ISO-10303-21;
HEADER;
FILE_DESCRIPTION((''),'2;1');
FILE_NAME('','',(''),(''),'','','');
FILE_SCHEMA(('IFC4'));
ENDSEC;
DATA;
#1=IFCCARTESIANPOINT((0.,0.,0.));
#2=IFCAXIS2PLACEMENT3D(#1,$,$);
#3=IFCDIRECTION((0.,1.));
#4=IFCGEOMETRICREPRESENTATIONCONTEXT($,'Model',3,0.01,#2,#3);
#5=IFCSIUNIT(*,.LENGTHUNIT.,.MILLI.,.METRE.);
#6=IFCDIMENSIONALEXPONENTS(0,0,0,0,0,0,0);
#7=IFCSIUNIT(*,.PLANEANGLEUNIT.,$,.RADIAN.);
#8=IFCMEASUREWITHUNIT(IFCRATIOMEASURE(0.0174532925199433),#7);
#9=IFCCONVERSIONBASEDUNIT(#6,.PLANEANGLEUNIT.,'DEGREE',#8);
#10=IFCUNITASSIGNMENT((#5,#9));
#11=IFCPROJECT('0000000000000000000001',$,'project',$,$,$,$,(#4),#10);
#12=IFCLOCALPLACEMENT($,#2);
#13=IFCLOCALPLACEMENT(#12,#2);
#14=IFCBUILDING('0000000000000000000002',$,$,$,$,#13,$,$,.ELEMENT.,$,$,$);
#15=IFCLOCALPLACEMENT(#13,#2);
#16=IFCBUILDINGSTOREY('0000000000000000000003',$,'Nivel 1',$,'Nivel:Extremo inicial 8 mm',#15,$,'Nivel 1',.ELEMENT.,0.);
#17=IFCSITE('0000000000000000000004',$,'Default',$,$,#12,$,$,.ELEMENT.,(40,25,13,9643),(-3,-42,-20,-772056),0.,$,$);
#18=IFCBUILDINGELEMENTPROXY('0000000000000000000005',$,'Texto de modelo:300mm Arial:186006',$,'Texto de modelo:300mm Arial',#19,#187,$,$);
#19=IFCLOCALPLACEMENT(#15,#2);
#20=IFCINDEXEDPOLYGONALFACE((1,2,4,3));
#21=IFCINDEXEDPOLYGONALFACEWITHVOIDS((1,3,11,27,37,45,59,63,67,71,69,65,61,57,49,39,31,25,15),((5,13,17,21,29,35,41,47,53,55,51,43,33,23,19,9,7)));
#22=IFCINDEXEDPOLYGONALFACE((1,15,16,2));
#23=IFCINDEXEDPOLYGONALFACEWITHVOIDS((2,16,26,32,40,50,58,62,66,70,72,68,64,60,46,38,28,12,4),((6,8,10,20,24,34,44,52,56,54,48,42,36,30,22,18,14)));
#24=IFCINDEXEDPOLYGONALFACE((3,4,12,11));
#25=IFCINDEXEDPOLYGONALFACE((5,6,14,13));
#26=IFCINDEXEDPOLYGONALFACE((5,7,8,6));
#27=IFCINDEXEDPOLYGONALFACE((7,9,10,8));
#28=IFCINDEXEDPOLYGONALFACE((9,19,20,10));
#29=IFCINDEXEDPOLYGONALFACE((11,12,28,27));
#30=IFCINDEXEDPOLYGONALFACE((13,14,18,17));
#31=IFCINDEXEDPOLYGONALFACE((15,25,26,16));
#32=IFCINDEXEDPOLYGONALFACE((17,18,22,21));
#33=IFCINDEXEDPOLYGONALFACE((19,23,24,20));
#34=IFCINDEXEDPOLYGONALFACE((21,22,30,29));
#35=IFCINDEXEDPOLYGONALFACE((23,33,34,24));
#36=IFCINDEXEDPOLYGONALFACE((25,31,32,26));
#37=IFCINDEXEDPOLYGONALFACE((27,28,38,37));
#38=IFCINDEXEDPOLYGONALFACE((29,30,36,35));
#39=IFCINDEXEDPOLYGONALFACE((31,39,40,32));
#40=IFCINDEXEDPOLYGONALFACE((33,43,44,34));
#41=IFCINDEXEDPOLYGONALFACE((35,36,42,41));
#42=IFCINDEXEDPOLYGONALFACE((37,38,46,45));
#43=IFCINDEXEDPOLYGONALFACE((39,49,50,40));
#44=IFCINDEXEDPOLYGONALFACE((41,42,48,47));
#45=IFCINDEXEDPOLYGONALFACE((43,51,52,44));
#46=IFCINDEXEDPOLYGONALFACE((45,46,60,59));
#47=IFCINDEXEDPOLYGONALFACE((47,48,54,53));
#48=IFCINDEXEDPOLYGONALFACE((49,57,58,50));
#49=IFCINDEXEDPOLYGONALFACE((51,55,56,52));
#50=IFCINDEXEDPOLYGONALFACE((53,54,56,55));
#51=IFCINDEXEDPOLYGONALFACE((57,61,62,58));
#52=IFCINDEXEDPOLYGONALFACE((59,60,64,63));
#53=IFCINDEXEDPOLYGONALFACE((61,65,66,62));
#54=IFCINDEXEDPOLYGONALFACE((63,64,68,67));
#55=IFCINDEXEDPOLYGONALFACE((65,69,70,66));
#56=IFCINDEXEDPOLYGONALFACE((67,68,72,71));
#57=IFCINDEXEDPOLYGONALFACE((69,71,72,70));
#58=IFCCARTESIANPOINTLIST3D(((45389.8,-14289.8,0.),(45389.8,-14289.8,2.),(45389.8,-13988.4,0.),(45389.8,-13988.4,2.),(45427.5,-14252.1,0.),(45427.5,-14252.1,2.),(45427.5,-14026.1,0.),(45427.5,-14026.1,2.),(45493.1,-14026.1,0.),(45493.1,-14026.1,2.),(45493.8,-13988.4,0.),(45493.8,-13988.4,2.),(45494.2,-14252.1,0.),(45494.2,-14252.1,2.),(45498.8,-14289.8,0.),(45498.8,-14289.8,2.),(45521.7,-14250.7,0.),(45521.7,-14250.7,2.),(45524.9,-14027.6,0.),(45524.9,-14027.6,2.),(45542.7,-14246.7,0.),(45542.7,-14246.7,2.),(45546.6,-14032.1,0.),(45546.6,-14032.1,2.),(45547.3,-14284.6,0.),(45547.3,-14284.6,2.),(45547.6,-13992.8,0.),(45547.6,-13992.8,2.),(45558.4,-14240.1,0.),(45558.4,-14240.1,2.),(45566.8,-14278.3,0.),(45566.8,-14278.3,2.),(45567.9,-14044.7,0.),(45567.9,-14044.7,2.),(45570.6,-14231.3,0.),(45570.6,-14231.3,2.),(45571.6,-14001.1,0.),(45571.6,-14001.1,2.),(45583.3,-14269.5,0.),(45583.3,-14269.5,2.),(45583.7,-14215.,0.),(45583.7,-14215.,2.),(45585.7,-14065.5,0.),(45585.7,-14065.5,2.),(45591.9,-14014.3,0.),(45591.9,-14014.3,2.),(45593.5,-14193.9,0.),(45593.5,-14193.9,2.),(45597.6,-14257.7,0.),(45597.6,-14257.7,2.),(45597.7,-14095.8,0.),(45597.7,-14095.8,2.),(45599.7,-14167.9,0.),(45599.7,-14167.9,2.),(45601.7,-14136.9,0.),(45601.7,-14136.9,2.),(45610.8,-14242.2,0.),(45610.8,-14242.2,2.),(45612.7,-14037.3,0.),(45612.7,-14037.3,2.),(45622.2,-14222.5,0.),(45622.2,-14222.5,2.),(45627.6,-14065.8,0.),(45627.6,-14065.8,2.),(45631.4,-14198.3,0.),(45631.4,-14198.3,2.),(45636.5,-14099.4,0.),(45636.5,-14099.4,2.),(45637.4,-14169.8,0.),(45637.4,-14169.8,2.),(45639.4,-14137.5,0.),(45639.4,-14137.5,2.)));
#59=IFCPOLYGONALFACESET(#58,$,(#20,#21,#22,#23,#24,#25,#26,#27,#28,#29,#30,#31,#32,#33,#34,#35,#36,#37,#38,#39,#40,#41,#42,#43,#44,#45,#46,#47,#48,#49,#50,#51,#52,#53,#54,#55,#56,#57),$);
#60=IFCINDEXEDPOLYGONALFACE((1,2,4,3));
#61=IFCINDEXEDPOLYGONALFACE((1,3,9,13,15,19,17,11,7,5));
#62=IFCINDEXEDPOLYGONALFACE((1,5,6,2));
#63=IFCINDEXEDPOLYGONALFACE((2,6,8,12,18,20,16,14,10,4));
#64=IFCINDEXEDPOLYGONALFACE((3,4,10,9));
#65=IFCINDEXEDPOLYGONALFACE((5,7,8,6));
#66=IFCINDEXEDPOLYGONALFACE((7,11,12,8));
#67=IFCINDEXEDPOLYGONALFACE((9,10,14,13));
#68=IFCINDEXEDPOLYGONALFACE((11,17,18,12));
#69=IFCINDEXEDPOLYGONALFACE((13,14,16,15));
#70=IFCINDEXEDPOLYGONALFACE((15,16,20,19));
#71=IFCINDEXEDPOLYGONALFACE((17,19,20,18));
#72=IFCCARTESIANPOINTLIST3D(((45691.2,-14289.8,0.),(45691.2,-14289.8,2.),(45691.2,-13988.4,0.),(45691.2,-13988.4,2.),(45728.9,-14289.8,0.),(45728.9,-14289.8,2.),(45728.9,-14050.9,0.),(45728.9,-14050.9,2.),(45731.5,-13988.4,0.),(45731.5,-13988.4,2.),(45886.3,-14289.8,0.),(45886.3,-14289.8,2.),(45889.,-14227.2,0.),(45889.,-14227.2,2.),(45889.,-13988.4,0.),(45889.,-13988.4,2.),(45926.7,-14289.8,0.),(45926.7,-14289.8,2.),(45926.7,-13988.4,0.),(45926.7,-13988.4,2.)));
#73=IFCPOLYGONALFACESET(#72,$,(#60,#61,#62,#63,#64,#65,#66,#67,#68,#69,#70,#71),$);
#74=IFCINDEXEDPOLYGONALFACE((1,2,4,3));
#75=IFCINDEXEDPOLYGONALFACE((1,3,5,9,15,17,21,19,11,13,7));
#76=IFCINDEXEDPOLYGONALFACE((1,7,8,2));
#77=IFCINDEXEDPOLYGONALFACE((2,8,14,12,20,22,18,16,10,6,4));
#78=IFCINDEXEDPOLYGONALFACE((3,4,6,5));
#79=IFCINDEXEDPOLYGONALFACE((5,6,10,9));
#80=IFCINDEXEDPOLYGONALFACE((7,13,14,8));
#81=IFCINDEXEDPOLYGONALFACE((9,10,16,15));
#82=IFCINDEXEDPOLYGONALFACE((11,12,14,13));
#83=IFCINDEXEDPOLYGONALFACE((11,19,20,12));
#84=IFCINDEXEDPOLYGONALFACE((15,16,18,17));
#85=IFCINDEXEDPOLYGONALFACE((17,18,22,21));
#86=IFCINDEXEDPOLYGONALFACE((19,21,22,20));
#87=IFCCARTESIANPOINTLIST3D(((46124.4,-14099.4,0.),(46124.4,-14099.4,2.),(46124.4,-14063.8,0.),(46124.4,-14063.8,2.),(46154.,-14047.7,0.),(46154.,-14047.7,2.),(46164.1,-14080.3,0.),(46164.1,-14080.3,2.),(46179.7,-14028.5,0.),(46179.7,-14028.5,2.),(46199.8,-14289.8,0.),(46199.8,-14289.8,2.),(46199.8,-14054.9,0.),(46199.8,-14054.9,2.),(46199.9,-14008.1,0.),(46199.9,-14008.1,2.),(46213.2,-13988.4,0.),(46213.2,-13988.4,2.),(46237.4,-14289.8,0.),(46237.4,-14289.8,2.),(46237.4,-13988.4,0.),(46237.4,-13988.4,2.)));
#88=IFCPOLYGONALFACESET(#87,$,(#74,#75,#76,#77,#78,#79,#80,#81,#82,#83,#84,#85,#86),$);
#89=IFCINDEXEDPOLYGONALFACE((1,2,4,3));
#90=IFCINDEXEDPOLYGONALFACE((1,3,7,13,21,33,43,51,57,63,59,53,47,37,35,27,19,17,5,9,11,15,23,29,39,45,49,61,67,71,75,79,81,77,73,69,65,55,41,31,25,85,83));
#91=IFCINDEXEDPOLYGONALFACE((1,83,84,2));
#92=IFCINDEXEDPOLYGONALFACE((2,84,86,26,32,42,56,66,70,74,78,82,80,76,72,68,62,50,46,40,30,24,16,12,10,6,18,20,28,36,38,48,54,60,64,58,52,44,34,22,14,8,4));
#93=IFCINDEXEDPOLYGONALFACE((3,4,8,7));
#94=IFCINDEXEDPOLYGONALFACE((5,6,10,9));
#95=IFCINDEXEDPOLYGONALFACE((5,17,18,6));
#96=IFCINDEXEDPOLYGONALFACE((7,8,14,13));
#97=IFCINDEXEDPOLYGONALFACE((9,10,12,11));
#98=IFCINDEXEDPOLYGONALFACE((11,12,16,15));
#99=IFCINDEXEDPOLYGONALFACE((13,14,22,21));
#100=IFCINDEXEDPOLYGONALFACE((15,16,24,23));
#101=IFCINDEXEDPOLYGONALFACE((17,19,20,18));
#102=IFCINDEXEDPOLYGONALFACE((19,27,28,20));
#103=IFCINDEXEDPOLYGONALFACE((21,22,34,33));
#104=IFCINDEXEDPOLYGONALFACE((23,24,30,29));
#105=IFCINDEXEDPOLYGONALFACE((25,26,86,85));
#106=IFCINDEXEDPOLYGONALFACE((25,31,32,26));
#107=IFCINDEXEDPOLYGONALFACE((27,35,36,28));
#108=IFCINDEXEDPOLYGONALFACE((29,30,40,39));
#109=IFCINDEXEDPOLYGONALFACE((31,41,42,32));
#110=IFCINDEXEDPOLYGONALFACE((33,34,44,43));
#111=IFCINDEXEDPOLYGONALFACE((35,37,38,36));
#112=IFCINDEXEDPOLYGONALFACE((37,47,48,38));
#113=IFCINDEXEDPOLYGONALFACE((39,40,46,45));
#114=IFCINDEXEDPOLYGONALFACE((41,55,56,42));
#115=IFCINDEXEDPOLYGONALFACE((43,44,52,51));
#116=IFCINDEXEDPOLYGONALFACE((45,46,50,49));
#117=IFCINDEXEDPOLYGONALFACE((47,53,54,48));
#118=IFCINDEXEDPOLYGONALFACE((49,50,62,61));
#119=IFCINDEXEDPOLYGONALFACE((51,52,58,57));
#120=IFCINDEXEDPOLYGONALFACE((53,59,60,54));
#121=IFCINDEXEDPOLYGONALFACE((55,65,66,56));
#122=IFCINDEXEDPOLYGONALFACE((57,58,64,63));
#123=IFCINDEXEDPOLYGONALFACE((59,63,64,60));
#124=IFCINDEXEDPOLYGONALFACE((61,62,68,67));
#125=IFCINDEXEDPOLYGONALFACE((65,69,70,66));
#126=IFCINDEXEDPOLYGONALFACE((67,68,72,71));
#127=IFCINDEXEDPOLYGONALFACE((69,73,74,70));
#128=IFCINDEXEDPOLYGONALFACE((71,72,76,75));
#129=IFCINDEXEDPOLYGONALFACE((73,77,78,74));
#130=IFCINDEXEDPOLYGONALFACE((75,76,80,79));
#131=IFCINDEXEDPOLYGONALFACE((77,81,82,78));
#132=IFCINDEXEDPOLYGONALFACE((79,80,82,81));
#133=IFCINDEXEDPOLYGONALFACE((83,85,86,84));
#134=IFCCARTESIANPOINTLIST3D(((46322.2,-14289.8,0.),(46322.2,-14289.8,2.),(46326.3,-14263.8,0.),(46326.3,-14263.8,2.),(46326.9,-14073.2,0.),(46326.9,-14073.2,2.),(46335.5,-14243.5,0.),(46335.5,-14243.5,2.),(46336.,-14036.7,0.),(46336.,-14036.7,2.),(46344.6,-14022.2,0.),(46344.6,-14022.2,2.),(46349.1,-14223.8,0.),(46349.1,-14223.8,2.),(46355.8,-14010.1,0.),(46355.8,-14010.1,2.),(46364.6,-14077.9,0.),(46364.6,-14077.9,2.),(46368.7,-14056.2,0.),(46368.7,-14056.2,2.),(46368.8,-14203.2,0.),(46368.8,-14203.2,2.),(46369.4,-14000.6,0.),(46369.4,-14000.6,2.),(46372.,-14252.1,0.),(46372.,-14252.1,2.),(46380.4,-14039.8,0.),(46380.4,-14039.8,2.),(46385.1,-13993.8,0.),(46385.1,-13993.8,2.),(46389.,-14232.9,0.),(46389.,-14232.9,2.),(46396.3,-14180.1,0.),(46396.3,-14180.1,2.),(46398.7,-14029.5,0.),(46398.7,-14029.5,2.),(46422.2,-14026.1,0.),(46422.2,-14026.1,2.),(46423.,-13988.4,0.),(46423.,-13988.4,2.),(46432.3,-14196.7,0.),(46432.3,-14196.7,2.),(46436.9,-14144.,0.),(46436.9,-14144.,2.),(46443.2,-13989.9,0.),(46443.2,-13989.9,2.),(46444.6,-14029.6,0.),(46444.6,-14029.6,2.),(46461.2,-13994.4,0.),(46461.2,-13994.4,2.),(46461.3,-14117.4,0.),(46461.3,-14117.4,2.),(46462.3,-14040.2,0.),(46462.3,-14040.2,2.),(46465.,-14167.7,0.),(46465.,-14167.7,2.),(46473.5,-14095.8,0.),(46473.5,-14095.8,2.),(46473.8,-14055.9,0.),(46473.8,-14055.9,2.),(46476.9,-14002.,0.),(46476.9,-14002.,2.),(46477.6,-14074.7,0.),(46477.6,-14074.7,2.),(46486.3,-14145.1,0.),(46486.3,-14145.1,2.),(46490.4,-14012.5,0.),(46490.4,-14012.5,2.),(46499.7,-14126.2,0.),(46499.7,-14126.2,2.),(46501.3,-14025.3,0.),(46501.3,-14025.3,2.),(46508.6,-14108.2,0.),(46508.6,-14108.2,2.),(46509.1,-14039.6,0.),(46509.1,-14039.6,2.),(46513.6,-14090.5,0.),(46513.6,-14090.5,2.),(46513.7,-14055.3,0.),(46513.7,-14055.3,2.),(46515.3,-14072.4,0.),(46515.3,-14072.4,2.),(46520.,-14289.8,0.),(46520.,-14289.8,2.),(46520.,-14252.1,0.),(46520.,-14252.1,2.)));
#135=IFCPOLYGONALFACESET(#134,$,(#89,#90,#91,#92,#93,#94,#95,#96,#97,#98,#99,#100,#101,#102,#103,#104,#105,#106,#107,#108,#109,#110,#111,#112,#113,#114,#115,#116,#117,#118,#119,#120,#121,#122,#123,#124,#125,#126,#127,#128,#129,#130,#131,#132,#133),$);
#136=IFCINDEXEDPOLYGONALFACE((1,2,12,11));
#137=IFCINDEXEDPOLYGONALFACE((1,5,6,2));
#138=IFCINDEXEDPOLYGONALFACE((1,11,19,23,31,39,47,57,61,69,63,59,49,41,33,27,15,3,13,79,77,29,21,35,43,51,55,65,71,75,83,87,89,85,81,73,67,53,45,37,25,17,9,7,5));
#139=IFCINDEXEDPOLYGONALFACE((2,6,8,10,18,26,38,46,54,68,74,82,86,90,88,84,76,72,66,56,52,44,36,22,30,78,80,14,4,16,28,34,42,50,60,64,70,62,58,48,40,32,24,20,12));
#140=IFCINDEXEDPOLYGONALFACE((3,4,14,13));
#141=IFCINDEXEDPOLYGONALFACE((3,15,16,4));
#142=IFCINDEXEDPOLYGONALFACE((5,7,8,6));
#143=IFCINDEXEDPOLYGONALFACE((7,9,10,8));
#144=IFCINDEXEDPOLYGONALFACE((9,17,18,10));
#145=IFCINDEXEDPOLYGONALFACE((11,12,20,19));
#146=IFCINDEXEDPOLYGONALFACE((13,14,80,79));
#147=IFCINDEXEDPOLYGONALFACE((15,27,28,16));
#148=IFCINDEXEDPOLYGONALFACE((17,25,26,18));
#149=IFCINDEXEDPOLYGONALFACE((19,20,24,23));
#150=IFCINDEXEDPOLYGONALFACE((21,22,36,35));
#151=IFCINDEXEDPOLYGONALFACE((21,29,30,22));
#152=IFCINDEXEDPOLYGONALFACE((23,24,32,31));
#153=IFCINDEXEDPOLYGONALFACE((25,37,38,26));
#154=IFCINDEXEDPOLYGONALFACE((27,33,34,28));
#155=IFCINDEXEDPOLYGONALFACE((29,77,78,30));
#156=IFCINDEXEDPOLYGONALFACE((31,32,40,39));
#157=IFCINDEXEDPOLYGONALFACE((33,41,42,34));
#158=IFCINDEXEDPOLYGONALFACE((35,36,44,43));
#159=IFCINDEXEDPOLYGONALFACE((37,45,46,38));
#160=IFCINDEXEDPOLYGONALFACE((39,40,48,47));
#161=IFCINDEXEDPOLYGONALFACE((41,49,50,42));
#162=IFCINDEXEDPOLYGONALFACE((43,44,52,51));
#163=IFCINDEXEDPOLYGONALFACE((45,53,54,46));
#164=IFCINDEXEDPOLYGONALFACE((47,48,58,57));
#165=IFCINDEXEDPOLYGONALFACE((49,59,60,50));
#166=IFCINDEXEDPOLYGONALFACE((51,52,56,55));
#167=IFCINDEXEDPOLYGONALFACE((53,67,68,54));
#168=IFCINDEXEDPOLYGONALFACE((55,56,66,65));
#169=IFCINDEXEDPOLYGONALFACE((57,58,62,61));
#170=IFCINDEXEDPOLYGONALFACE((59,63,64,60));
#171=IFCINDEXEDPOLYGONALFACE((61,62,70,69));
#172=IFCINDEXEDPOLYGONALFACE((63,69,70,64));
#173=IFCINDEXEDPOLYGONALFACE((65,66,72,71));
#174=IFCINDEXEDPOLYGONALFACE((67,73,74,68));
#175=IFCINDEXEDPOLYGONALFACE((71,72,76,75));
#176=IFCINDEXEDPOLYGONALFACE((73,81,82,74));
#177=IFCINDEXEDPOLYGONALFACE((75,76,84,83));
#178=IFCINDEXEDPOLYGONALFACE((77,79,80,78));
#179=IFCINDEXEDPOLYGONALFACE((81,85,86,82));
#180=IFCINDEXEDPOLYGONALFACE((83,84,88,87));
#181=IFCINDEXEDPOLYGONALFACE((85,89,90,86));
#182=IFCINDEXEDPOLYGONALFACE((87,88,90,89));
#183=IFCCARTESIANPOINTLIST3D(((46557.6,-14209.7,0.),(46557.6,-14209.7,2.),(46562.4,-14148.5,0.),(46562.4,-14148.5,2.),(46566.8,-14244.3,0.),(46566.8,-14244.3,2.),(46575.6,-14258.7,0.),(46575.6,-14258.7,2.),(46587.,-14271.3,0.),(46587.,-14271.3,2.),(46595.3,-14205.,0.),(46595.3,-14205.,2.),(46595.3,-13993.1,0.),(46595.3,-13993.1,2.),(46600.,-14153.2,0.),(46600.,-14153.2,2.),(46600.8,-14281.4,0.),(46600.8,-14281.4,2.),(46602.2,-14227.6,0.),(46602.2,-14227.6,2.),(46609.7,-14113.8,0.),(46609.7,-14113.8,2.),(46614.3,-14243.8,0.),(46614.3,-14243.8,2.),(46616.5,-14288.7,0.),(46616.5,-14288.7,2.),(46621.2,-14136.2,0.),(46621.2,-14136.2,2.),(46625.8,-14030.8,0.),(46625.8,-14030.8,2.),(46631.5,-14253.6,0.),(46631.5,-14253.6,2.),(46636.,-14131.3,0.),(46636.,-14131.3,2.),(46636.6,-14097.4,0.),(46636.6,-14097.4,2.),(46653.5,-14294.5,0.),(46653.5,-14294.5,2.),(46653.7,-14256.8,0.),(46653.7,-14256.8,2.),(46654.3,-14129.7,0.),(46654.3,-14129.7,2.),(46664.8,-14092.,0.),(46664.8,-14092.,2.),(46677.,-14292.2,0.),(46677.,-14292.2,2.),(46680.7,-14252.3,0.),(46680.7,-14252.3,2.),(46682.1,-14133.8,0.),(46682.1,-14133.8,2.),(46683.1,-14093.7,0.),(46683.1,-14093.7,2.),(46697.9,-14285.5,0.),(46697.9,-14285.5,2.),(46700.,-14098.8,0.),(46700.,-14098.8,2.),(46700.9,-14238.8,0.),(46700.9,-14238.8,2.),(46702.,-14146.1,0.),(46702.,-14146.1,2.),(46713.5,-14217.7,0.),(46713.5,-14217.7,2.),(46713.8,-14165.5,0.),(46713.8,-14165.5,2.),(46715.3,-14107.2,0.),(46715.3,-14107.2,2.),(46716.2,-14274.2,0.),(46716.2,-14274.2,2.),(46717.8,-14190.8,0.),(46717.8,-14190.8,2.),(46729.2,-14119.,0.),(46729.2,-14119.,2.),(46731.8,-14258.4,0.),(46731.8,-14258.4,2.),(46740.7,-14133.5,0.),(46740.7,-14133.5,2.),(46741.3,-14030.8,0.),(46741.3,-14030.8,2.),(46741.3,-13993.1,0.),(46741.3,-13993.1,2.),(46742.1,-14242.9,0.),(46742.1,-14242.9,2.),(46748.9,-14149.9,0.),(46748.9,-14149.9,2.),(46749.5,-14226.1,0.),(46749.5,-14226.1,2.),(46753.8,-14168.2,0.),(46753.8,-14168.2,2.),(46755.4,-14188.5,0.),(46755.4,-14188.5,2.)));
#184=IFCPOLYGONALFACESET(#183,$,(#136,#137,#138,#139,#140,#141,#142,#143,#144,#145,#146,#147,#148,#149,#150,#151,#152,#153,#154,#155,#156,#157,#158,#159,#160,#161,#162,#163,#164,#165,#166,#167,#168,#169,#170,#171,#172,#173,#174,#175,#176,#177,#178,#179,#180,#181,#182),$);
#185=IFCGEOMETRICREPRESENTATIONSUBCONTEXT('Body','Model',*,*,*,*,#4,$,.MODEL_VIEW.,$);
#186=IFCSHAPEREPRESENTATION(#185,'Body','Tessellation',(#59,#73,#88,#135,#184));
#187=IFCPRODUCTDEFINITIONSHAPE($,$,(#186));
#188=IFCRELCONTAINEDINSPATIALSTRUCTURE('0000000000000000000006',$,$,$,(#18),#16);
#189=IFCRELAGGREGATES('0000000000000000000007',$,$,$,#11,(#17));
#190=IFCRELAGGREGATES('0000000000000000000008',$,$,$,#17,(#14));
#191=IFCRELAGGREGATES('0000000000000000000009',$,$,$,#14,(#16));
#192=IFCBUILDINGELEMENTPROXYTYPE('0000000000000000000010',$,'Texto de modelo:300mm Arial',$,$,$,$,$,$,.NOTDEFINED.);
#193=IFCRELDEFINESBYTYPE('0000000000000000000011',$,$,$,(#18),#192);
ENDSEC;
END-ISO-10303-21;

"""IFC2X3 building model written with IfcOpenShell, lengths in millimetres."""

from ifc_helpers import new_model, entity, si_unit, converted_unit, direction, frame, origin, place, context, subcontext, project, spatial, polyline, outline, extrude, type_object, element, save


model = new_model("IFC2X3")

# Units and contexts
model_context = context("Model", 3, precision=0.01, world=origin(), true_north=direction((0.0, 1.0)))
body_context = subcontext(model_context, "Body", "Model", "MODEL_VIEW")
ifc_project = project(units=[si_unit("LENGTHUNIT", "METRE", prefix="MILLI"), converted_unit("PLANEANGLEUNIT", "DEGREE", entity("IfcRatioMeasure", 0.0174532925199433), si_unit("PLANEANGLEUNIT", "RADIAN"), dimensions=[0, 0, 0, 0, 0, 0, 0])], contexts=[model_context])

# Site, building, storey
site_placement = place(None, origin())
site = spatial("IfcSite", under=ifc_project, at=site_placement, Name="Default", CompositionType="ELEMENT", RefLatitude=(40, 25, 13, 9643), RefLongitude=(-3, -42, -20, -772056), RefElevation=0.0)
building_placement = place(site_placement, origin())
building = spatial("IfcBuilding", under=site, at=building_placement, CompositionType="ELEMENT")
storey_placement = place(building_placement, origin())
storey = spatial("IfcBuildingStorey", under=building, at=storey_placement, Name="Nivel 1", ObjectType="Nivel:Extremo inicial 8 mm", LongName="Nivel 1", CompositionType="ELEMENT", Elevation=0.0)

# Building element proxy
building_element_proxy_type_1 = type_object("IfcBuildingElementProxyType", Name="Texto de modelo:300mm Arial", PredefinedType="NOTDEFINED")
proxy_1_placement = place(storey_placement, frame((45389.8, -14294.5, 0.0)))
element("IfcBuildingElementProxy", 1, at=proxy_1_placement, inside=storey, type_object=building_element_proxy_type_1, Name="Texto de modelo:300mm Arial:186006", ObjectType="Texto de modelo:300mm Arial", context=body_context, shape_type="SweptSolid", body=[
    extrude(outline(polyline([(-178.4, -141.0), (-69.4, -141.0), (-21.0, -135.8), (-1.4, -129.5), (15.0, -120.7), (29.4, -108.9), (42.6, -93.4), (54.0, -73.7), (63.2, -49.5), (69.2, -21.0), (71.2, 11.3), (68.2, 49.4), (59.3, 83.0), (44.5, 111.5), (23.7, 134.5), (3.4, 147.7), (-20.6, 156.1), (-74.4, 160.4), (-178.4, 160.4), (-178.4, -141.0)]), holes=[polyline([(-140.7, -103.3), (-140.7, 122.7), (-75.1, 122.7), (-43.3, 121.2), (-21.7, 116.7), (-0.4, 104.1), (17.4, 83.3), (29.5, 53.0), (33.5, 11.9), (31.5, -19.1), (25.3, -45.1), (15.5, -66.2), (2.4, -82.5), (-9.8, -91.3), (-25.6, -97.9), (-46.5, -101.9), (-74.1, -103.3), (-140.7, -103.3)])]), frame((178.4, 145.7, 0.0)), (0.0, 0.0, 1.0), 2.0),
    extrude(outline(polyline([(-117.7, -150.7), (-80.1, -150.7), (-80.1, 88.1), (77.4, -150.7), (117.7, -150.7), (117.7, 150.7), (80.1, 150.7), (80.1, -88.1), (-77.4, 150.7), (-117.7, 150.7), (-117.7, -150.7)])), frame((419.1, 155.4, 0.0)), (0.0, 0.0, 1.0), 2.0),
    extrude(outline(polyline([(-204.4, -52.5), (97.0, -52.5), (97.0, -28.2), (77.2, -14.9), (56.9, 5.3), (37.7, 30.9), (21.6, 60.5), (-14.0, 60.5), (5.0, 20.8), (30.4, -14.9), (-204.4, -14.9), (-204.4, -52.5)])), frame((795.1, 209.1, 0.0), z_axis=(0.0, 0.0, 1.0), x_axis=(0.0, 1.0, 0.0)), (0.0, 0.0, 1.0), 2.0),
    extrude(outline(polyline([(-91.6, -150.5), (-91.6, -188.2), (106.2, -188.2), (102.1, -162.2), (92.9, -141.9), (79.3, -122.2), (59.6, -101.6), (32.1, -78.5), (-8.5, -42.4), (-32.9, -15.8), (-45.1, 5.8), (-49.2, 26.9), (-45.4, 45.8), (-33.9, 61.4), (-16.2, 72.0), (6.2, 75.5), (29.7, 72.1), (48.0, 61.8), (59.7, 45.4), (63.8, 23.7), (101.5, 28.4), (92.4, 64.9), (83.8, 79.4), (72.6, 91.5), (59.0, 101.0), (43.3, 107.8), (5.4, 113.2), (-14.8, 111.7), (-32.8, 107.2), (-48.5, 99.6), (-62.0, 89.1), (-72.9, 76.3), (-80.7, 62.0), (-85.3, 46.3), (-86.9, 29.2), (-85.2, 11.2), (-80.2, -6.5), (-71.3, -24.6), (-57.9, -43.5), (-36.6, -66.1), (-3.9, -95.1), (39.4, -131.3), (56.4, -150.5), (-91.6, -150.5)])), frame((1038.6, 192.9, 0.0), z_axis=(0.0, 0.0, -1.0), x_axis=(-1.0, 0.0, 0.0)), (0.0, 0.0, -1.0), 2.0),
    extrude(outline(polyline([(1.4, -113.1), (37.2, -113.1), (53.4, -108.4), (68.5, -100.5), (81.8, -89.8), (92.9, -76.5), (108.0, -42.2), (111.8, -18.9), (110.6, 3.0), (104.4, 23.5), (93.2, 42.7), (80.9, 56.7), (66.6, 68.1), (31.7, 83.5), (11.7, 87.1), (-7.3, 87.1), (-25.2, 83.4), (-42.2, 76.0), (-57.1, 65.7), (-69.2, 53.0), (-78.5, 38.0), (-84.8, 20.7), (-86.8, -7.9), (-77.9, -38.1), (-154.0, -1.2), (-124.3, 110.4), (-160.7, 120.1), (-198.2, -21.0), (-56.5, -92.8), (-42.3, -57.6), (-53.3, -32.8), (-54.2, -17.2), (-51.1, 0.9), (-40.0, 26.8), (-23.0, 42.8), (-1.2, 49.2), (24.3, 46.5), (49.2, 35.5), (66.3, 17.9), (74.2, -5.1), (71.6, -32.4), (62.8, -53.0), (48.9, -67.1), (30.2, -74.6), (6.6, -75.5), (1.4, -113.1)])), frame((1276.7, 115.2, 0.0), z_axis=(0.0, 0.0, 1.0), x_axis=(0.256974, -0.966418, 0.0)), (0.0, 0.0, 1.0), 2.0),
])

save(model, "model.ifc")
